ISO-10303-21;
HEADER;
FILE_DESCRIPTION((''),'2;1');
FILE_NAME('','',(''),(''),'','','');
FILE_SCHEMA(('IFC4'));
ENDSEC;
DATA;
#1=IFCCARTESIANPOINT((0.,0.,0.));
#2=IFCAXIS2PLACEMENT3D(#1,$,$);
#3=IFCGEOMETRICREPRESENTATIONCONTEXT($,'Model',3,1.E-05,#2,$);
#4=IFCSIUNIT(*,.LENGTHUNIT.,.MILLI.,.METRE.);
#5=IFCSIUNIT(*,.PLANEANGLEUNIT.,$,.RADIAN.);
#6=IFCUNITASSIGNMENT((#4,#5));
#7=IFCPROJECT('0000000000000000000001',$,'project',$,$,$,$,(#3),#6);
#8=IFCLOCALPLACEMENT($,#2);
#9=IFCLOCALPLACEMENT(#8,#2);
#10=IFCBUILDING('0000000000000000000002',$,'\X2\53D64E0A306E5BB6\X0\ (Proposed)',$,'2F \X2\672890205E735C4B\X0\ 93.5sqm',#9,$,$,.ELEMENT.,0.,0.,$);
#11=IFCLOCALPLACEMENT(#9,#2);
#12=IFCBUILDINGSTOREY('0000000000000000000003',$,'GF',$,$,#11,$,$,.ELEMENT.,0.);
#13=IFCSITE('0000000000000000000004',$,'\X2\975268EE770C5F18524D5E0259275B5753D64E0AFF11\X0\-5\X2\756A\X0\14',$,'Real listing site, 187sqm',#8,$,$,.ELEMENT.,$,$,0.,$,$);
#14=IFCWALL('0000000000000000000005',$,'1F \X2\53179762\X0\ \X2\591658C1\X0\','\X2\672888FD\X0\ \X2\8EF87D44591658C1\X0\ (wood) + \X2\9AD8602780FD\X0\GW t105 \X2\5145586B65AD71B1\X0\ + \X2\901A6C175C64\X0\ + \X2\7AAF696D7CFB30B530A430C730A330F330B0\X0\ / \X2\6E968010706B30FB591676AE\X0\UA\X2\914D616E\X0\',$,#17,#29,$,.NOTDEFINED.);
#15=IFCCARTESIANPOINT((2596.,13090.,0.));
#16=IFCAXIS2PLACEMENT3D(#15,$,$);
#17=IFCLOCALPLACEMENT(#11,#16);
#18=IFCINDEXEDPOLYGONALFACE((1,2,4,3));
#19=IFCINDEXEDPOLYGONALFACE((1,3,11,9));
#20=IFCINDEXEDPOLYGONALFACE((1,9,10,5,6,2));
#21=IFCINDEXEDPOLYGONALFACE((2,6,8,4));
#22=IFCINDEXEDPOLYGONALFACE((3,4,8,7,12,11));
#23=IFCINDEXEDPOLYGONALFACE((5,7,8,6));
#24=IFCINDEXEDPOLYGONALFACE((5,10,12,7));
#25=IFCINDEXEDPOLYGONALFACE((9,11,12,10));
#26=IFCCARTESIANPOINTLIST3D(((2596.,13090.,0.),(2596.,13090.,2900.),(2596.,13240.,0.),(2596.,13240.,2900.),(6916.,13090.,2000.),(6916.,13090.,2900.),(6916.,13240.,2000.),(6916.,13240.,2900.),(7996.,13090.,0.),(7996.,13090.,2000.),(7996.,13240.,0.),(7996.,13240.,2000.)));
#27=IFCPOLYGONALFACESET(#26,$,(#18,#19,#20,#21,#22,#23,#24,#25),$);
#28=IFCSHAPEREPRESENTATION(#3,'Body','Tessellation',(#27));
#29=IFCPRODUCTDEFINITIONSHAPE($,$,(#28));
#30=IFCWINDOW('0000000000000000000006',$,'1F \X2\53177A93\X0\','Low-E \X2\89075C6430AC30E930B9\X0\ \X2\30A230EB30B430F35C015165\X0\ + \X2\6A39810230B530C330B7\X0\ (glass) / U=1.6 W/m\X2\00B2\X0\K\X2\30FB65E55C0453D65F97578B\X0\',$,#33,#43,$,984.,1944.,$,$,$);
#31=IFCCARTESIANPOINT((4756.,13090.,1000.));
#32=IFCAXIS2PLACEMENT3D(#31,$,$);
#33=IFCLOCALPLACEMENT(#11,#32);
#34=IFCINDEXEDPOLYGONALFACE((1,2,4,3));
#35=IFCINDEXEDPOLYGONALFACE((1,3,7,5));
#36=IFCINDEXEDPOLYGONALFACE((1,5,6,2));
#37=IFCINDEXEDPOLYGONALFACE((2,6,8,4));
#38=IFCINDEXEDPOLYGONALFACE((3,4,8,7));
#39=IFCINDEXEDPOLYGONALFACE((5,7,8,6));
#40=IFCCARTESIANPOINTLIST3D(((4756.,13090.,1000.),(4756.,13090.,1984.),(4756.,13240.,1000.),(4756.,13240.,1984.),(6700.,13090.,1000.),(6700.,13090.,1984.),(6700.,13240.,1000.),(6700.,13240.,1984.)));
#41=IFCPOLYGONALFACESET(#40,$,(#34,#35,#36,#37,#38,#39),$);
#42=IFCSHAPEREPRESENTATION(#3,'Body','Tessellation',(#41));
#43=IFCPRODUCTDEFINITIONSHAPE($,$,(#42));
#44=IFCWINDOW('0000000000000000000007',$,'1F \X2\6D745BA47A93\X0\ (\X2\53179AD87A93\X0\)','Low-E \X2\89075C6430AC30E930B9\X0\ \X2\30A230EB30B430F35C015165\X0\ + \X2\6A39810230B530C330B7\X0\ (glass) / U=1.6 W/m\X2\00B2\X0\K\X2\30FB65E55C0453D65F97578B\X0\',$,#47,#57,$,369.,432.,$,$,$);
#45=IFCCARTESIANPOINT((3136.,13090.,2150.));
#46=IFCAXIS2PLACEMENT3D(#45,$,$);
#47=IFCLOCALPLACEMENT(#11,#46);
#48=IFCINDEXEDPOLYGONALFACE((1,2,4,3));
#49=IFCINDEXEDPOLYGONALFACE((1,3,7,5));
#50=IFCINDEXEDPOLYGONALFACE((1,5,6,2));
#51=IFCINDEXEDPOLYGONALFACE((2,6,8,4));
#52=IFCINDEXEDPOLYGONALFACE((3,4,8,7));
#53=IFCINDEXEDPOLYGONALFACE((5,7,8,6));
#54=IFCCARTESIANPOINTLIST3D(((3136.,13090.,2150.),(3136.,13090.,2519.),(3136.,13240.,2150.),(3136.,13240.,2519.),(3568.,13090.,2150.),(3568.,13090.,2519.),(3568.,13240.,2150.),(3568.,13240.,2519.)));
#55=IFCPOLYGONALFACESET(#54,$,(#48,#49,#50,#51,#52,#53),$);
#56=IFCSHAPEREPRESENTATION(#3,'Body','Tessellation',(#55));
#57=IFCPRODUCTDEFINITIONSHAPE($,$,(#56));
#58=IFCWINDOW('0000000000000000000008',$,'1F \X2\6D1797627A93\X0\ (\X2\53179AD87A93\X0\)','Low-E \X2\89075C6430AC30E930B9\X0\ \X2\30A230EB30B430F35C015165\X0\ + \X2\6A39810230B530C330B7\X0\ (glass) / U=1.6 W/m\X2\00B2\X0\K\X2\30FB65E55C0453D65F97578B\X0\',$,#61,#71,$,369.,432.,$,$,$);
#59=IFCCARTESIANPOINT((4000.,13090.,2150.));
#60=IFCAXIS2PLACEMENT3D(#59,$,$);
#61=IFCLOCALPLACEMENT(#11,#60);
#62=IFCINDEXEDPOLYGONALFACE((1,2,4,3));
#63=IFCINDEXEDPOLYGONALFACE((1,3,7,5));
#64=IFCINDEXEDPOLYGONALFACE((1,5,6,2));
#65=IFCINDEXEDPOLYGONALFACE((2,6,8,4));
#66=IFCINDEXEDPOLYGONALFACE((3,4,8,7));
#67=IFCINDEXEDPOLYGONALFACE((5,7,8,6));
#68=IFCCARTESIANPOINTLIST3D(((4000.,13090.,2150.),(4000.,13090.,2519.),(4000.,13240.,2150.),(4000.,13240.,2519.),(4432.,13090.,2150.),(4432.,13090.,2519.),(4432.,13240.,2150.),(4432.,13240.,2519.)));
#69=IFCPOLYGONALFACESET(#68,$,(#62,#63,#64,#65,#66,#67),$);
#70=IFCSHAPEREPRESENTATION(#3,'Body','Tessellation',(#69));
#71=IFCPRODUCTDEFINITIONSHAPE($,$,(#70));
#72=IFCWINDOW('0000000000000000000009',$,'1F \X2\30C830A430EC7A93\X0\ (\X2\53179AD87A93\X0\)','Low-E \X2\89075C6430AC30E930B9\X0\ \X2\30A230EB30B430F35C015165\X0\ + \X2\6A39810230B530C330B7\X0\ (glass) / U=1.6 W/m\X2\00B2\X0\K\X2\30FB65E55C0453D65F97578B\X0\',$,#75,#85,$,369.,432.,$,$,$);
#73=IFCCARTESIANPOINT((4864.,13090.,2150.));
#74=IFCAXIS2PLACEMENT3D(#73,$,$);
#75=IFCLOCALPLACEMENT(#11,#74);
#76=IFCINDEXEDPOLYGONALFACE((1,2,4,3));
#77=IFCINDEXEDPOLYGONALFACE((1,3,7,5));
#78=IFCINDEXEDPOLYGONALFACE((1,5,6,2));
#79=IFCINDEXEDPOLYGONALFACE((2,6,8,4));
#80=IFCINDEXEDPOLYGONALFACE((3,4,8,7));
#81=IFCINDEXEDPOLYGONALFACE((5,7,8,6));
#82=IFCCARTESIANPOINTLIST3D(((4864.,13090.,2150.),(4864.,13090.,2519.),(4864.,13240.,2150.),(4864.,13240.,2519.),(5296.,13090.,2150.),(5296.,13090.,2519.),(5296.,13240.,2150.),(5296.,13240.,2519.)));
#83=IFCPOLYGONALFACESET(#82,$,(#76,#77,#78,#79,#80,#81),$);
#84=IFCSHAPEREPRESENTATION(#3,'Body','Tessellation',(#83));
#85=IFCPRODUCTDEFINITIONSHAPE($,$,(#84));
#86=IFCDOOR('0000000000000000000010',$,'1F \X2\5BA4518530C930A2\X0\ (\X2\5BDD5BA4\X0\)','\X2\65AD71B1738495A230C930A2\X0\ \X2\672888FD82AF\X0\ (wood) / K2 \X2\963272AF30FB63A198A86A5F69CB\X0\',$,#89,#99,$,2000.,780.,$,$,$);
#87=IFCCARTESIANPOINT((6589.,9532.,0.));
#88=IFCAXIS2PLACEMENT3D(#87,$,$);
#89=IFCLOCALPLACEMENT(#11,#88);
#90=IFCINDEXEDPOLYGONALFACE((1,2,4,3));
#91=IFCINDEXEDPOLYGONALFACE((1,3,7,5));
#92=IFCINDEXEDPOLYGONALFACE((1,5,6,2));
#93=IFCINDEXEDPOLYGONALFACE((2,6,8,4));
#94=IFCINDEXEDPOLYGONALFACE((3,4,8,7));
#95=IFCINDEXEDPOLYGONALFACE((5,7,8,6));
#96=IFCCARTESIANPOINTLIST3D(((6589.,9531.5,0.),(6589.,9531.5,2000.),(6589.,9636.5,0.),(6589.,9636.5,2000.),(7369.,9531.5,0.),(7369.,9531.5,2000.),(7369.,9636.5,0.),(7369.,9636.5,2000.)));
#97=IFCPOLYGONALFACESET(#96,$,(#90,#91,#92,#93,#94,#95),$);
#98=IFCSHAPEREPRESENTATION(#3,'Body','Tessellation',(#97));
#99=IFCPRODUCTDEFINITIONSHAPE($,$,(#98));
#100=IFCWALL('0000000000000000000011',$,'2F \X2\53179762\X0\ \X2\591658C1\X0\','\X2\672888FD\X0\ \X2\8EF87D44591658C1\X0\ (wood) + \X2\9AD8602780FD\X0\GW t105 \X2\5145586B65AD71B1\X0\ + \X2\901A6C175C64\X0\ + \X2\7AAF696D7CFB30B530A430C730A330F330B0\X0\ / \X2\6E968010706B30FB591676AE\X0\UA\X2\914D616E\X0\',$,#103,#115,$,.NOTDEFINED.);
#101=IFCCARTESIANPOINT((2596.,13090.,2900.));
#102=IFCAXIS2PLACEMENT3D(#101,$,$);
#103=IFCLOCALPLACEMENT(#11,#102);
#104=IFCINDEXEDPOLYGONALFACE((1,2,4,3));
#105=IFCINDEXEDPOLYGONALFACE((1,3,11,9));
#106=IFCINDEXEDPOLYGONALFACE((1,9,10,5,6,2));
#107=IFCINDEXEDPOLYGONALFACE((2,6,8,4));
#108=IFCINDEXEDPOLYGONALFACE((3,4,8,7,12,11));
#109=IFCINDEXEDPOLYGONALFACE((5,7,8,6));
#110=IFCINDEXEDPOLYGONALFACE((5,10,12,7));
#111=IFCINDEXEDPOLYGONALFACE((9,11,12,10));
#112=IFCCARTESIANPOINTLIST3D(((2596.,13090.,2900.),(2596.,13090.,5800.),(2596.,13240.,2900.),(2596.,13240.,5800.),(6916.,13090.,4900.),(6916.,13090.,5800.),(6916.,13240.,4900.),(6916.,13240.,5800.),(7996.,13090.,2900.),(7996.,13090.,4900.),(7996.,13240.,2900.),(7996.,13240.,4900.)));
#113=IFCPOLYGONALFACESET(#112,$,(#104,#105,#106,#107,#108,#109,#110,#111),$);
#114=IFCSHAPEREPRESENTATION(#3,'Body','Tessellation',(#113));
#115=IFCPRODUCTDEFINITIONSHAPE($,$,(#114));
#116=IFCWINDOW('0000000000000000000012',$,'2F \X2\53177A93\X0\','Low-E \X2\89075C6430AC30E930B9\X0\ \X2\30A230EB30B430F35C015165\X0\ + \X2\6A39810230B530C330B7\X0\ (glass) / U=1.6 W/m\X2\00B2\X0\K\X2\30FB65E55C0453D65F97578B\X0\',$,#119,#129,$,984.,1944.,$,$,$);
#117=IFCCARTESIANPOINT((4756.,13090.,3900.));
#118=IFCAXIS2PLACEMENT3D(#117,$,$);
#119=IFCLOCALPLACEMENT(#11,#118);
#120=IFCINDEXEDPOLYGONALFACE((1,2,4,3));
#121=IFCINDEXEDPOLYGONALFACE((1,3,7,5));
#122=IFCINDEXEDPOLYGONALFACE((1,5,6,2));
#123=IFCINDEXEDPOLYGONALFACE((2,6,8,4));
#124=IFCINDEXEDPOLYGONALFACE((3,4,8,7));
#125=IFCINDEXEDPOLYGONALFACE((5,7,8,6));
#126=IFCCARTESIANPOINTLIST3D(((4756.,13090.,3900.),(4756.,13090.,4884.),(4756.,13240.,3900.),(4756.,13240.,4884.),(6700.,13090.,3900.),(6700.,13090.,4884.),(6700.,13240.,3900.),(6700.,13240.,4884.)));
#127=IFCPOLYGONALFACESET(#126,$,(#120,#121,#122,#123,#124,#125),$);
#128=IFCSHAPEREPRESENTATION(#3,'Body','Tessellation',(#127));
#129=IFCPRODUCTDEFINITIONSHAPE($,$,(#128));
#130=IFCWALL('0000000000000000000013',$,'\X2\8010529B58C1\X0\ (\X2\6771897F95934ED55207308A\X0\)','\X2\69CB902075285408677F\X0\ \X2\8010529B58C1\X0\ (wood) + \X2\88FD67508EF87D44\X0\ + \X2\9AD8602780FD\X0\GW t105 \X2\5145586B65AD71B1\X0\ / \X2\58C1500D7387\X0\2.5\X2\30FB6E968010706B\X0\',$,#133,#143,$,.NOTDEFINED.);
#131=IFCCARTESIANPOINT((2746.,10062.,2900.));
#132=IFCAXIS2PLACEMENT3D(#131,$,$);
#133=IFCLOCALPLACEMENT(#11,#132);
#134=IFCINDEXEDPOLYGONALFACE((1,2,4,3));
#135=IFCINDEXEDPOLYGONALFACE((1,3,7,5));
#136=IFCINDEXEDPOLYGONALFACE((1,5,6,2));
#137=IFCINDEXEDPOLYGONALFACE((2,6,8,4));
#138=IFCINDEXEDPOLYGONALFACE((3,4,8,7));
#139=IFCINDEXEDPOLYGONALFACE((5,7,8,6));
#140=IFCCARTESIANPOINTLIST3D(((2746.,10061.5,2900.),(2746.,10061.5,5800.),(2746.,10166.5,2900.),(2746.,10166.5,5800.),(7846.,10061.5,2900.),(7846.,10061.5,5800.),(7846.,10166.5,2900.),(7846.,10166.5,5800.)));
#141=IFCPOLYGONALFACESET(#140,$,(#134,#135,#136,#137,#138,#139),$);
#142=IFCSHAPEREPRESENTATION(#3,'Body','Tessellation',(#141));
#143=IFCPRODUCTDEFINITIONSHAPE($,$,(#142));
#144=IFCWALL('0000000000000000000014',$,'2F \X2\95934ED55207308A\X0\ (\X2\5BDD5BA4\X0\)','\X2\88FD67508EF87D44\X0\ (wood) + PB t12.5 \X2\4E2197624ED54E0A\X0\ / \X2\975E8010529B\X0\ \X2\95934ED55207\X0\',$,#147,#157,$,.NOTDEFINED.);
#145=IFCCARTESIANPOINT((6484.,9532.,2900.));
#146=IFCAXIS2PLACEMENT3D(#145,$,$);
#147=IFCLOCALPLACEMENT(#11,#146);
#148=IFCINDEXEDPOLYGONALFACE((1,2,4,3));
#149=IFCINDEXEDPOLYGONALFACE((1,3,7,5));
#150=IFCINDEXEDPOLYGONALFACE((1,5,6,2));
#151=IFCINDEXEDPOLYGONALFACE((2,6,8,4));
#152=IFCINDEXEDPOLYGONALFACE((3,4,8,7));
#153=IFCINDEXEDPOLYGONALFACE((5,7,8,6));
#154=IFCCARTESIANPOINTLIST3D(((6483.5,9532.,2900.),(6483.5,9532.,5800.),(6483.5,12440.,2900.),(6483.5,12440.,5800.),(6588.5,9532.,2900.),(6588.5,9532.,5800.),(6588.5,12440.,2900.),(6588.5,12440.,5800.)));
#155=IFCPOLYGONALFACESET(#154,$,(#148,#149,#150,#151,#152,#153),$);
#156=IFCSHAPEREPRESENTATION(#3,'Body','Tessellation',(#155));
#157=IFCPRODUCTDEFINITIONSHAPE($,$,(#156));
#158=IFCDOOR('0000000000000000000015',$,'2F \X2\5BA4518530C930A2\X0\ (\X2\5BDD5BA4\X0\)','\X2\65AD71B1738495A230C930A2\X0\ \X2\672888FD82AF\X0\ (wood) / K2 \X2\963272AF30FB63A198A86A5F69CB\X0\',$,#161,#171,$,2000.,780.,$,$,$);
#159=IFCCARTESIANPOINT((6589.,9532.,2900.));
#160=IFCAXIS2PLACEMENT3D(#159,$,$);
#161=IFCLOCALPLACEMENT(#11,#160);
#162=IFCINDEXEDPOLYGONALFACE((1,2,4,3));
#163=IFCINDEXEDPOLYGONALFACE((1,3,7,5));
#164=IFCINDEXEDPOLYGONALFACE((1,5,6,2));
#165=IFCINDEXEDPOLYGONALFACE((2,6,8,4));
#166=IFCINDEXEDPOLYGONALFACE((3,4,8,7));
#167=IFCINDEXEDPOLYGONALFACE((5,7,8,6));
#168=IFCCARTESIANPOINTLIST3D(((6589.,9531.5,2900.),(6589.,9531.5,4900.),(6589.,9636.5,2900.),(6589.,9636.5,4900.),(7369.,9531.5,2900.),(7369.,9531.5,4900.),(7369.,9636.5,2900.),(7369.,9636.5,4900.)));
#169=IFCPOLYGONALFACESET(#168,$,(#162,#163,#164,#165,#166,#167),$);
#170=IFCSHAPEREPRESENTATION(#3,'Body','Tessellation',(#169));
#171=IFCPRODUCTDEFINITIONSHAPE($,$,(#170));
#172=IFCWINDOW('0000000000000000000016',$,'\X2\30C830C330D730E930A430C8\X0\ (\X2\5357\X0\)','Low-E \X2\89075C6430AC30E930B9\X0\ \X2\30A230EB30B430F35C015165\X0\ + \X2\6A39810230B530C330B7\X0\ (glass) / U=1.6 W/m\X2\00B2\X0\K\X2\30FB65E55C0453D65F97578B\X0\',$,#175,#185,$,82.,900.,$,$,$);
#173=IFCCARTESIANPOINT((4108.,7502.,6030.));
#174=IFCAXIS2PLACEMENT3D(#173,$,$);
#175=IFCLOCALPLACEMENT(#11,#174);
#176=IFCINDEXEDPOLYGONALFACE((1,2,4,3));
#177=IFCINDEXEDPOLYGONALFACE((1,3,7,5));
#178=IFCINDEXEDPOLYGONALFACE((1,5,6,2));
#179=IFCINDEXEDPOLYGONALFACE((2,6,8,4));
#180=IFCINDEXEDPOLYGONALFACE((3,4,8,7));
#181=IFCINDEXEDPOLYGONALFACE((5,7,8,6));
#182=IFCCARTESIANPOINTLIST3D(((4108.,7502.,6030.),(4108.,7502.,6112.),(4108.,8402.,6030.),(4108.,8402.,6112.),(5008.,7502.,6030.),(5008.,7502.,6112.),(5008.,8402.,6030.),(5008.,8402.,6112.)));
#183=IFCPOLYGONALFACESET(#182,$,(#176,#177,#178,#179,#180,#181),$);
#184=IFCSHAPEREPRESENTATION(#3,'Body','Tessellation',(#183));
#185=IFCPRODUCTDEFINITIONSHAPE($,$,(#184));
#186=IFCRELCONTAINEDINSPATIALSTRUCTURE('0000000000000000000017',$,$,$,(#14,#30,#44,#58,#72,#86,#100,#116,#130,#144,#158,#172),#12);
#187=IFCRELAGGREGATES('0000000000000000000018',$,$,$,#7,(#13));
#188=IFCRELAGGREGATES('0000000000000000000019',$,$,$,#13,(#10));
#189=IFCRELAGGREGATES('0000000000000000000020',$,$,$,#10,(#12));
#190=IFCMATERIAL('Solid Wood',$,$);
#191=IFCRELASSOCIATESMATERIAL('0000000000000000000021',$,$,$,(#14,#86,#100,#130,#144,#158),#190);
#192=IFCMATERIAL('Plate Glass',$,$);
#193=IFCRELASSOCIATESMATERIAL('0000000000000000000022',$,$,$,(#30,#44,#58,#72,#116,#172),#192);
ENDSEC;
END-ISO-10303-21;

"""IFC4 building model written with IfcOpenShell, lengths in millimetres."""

from ifc_helpers import new_model, si_unit, frame, frame_2d, origin, place, context, project, spatial, rectangle, extrude, material, element, fill, save


model = new_model("IFC4")

# Units and contexts
model_context = context("Model", 3, precision=1e-05, world=origin())
ifc_project = project(units=[si_unit("LENGTHUNIT", "METRE", prefix="MILLI"), si_unit("PLANEANGLEUNIT", "RADIAN")], contexts=[model_context])

# Site, building, storey
site_placement = place(None, origin())
site = spatial("IfcSite", under=ifc_project, at=site_placement, Name="青森県弘前市大字取上１-5番14", ObjectType="Real listing site, 187sqm", CompositionType="ELEMENT", RefElevation=0.0)
building_placement = place(site_placement, origin())
building = spatial("IfcBuilding", under=site, at=building_placement, Name="取上の家 (Proposed)", ObjectType="2F 木造平屋 93.5sqm", CompositionType="ELEMENT", ElevationOfRefHeight=0.0, ElevationOfTerrain=0.0)
storey_placement = place(building_placement, origin())
storey = spatial("IfcBuildingStorey", under=building, at=storey_placement, Name="GF", CompositionType="ELEMENT", Elevation=0.0)

# Wall, openings, windows
ifc_material_1 = material(Name="Solid Wood")
wall_1_placement = place(storey_placement, frame((2596.0, 13090.0, 0.0)))
wall_1 = element("IfcWall", 1, at=wall_1_placement, inside=storey, material=ifc_material_1, Name="1F 北面 外壁", Description="木製 軸組外壁 (wood) + 高性能GW t105 充填断熱 + 通気層 + 窯業系サイディング / 準耐火・外皮UA配慮", PredefinedType="NOTDEFINED", context=model_context, shape_type="SweptSolid", body=[
    extrude(rectangle(XDim=5400.0, YDim=150.0, at=frame_2d((2700.0, 75.0))), frame((2596.0, 13090.0, 0.0)), (0.0, 0.0, 1.0), 2900.0),
])
opening_1_placement = place(storey_placement, frame((4756.0, 13090.0, 1000.0)))
opening_1 = element("IfcOpeningElement", 2, at=opening_1_placement, cuts=wall_1, PredefinedType="NOTDEFINED", context=model_context, shape_type="SweptSolid", body=[
    extrude(rectangle(XDim=1944.0, YDim=150.0, at=frame_2d((972.0, 75.0))), frame((4756.0, 13090.0, 1000.0)), (0.0, 0.0, 1.0), 984.0),
])
opening_2_placement = place(storey_placement, frame((3136.0, 13090.0, 2150.0)))
opening_2 = element("IfcOpeningElement", 3, at=opening_2_placement, cuts=wall_1, PredefinedType="NOTDEFINED", context=model_context, shape_type="SweptSolid", body=[
    extrude(rectangle(XDim=432.0, YDim=150.0, at=frame_2d((216.0, 75.0))), frame((3136.0, 13090.0, 2150.0)), (0.0, 0.0, 1.0), 369.0),
])
opening_3_placement = place(storey_placement, frame((4000.0, 13090.0, 2150.0)))
opening_3 = element("IfcOpeningElement", 4, at=opening_3_placement, cuts=wall_1, PredefinedType="NOTDEFINED", context=model_context, shape_type="SweptSolid", body=[
    extrude(rectangle(XDim=432.0, YDim=150.0, at=frame_2d((216.0, 75.0))), frame((4000.0, 13090.0, 2150.0)), (0.0, 0.0, 1.0), 369.0),
])
opening_4_placement = place(storey_placement, frame((4864.0, 13090.0, 2150.0)))
opening_4 = element("IfcOpeningElement", 5, at=opening_4_placement, cuts=wall_1, PredefinedType="NOTDEFINED", context=model_context, shape_type="SweptSolid", body=[
    extrude(rectangle(XDim=432.0, YDim=150.0, at=frame_2d((216.0, 75.0))), frame((4864.0, 13090.0, 2150.0)), (0.0, 0.0, 1.0), 369.0),
])
ifc_material_2 = material(Name="Plate Glass")
window_1_placement = place(storey_placement, frame((4756.0, 13090.0, 1000.0)))
window_1 = element("IfcWindow", 6, at=window_1_placement, inside=storey, material=ifc_material_2, Name="1F 北窓", Description="Low-E 複層ガラス アルゴン封入 + 樹脂サッシ (glass) / U=1.6 W/m²K・日射取得型", OverallHeight=984.0, OverallWidth=1944.0, context=model_context, shape_type="SweptSolid", body=[
    extrude(rectangle(XDim=1944.0, YDim=150.0, at=frame_2d((972.0, 75.0))), frame((4756.0, 13090.0, 1000.0)), (0.0, 0.0, 1.0), 984.0),
])
fill(opening_1, window_1)
window_2_placement = place(storey_placement, frame((3136.0, 13090.0, 2150.0)))
window_2 = element("IfcWindow", 7, at=window_2_placement, inside=storey, material=ifc_material_2, Name="1F 浴室窓 (北高窓)", Description="Low-E 複層ガラス アルゴン封入 + 樹脂サッシ (glass) / U=1.6 W/m²K・日射取得型", OverallHeight=369.0, OverallWidth=432.0, context=model_context, shape_type="SweptSolid", body=[
    extrude(rectangle(XDim=432.0, YDim=150.0, at=frame_2d((216.0, 75.0))), frame((3136.0, 13090.0, 2150.0)), (0.0, 0.0, 1.0), 369.0),
])
fill(opening_2, window_2)
window_3_placement = place(storey_placement, frame((4000.0, 13090.0, 2150.0)))
window_3 = element("IfcWindow", 8, at=window_3_placement, inside=storey, material=ifc_material_2, Name="1F 洗面窓 (北高窓)", Description="Low-E 複層ガラス アルゴン封入 + 樹脂サッシ (glass) / U=1.6 W/m²K・日射取得型", OverallHeight=369.0, OverallWidth=432.0, context=model_context, shape_type="SweptSolid", body=[
    extrude(rectangle(XDim=432.0, YDim=150.0, at=frame_2d((216.0, 75.0))), frame((4000.0, 13090.0, 2150.0)), (0.0, 0.0, 1.0), 369.0),
])
fill(opening_3, window_3)
window_4_placement = place(storey_placement, frame((4864.0, 13090.0, 2150.0)))
window_4 = element("IfcWindow", 9, at=window_4_placement, inside=storey, material=ifc_material_2, Name="1F トイレ窓 (北高窓)", Description="Low-E 複層ガラス アルゴン封入 + 樹脂サッシ (glass) / U=1.6 W/m²K・日射取得型", OverallHeight=369.0, OverallWidth=432.0, context=model_context, shape_type="SweptSolid", body=[
    extrude(rectangle(XDim=432.0, YDim=150.0, at=frame_2d((216.0, 75.0))), frame((4864.0, 13090.0, 2150.0)), (0.0, 0.0, 1.0), 369.0),
])
fill(opening_4, window_4)

# Door
door_1_placement = place(storey_placement, frame((6589.0, 9532.0, 0.0)))
element("IfcDoor", 10, at=door_1_placement, inside=storey, material=ifc_material_1, Name="1F 室内ドア (寝室)", Description="断熱玄関ドア 木製芯 (wood) / K2 防犯・採風機構", OverallHeight=2000.0, OverallWidth=780.0, context=model_context, shape_type="SweptSolid", body=[
    extrude(rectangle(XDim=780.0, YDim=105.0, at=frame_2d((390.0, 52.0))), frame((6589.0, 9532.0, 0.0)), (0.0, 0.0, 1.0), 2000.0),
])

# Wall, opening, window
wall_2_placement = place(storey_placement, frame((2596.0, 13090.0, 2900.0)))
wall_2 = element("IfcWall", 11, at=wall_2_placement, inside=storey, material=ifc_material_1, Name="2F 北面 外壁", Description="木製 軸組外壁 (wood) + 高性能GW t105 充填断熱 + 通気層 + 窯業系サイディング / 準耐火・外皮UA配慮", PredefinedType="NOTDEFINED", context=model_context, shape_type="SweptSolid", body=[
    extrude(rectangle(XDim=5400.0, YDim=150.0, at=frame_2d((2700.0, 75.0))), frame((2596.0, 13090.0, 2900.0)), (0.0, 0.0, 1.0), 2900.0),
])
opening_5_placement = place(storey_placement, frame((4756.0, 13090.0, 3900.0)))
opening_5 = element("IfcOpeningElement", 12, at=opening_5_placement, cuts=wall_2, PredefinedType="NOTDEFINED", context=model_context, shape_type="SweptSolid", body=[
    extrude(rectangle(XDim=1944.0, YDim=150.0, at=frame_2d((972.0, 75.0))), frame((4756.0, 13090.0, 3900.0)), (0.0, 0.0, 1.0), 984.0),
])
window_5_placement = place(storey_placement, frame((4756.0, 13090.0, 3900.0)))
window_5 = element("IfcWindow", 13, at=window_5_placement, inside=storey, material=ifc_material_2, Name="2F 北窓", Description="Low-E 複層ガラス アルゴン封入 + 樹脂サッシ (glass) / U=1.6 W/m²K・日射取得型", OverallHeight=984.0, OverallWidth=1944.0, context=model_context, shape_type="SweptSolid", body=[
    extrude(rectangle(XDim=1944.0, YDim=150.0, at=frame_2d((972.0, 75.0))), frame((4756.0, 13090.0, 3900.0)), (0.0, 0.0, 1.0), 984.0),
])
fill(opening_5, window_5)

# Walls
wall_3_placement = place(storey_placement, frame((2746.0, 10062.0, 2900.0)))
element("IfcWall", 14, at=wall_3_placement, inside=storey, material=ifc_material_1, Name="耐力壁 (東西間仕切り)", Description="構造用合板 耐力壁 (wood) + 製材軸組 + 高性能GW t105 充填断熱 / 壁倍率2.5・準耐火", PredefinedType="NOTDEFINED", context=model_context, shape_type="SweptSolid", body=[
    extrude(rectangle(XDim=5100.0, YDim=105.0, at=frame_2d((2550.0, 52.0))), frame((2746.0, 10062.0, 2900.0)), (0.0, 0.0, 1.0), 2900.0),
])
wall_4_placement = place(storey_placement, frame((6484.0, 9532.0, 2900.0)))
element("IfcWall", 15, at=wall_4_placement, inside=storey, material=ifc_material_1, Name="2F 間仕切り (寝室)", Description="製材軸組 (wood) + PB t12.5 両面仕上 / 非耐力 間仕切", PredefinedType="NOTDEFINED", context=model_context, shape_type="SweptSolid", body=[
    extrude(rectangle(XDim=105.0, YDim=2908.0, at=frame_2d((52.0, 1454.0))), frame((6484.0, 9532.0, 2900.0)), (0.0, 0.0, 1.0), 2900.0),
])

# Door
door_2_placement = place(storey_placement, frame((6589.0, 9532.0, 2900.0)))
element("IfcDoor", 16, at=door_2_placement, inside=storey, material=ifc_material_1, Name="2F 室内ドア (寝室)", Description="断熱玄関ドア 木製芯 (wood) / K2 防犯・採風機構", OverallHeight=2000.0, OverallWidth=780.0, context=model_context, shape_type="SweptSolid", body=[
    extrude(rectangle(XDim=780.0, YDim=105.0, at=frame_2d((390.0, 52.0))), frame((6589.0, 9532.0, 2900.0)), (0.0, 0.0, 1.0), 2000.0),
])

# Window
window_6_placement = place(storey_placement, frame((4108.0, 7502.0, 6030.0)))
element("IfcWindow", 17, at=window_6_placement, inside=storey, material=ifc_material_2, Name="トップライト (南)", Description="Low-E 複層ガラス アルゴン封入 + 樹脂サッシ (glass) / U=1.6 W/m²K・日射取得型", OverallHeight=82.0, OverallWidth=900.0, context=model_context, shape_type="SweptSolid", body=[
    extrude(rectangle(XDim=900.0, YDim=900.0, at=frame_2d((450.0, 450.0))), frame((4108.0, 7502.0, 6030.0)), (0.0, 0.0, 1.0), 82.0),
])

save(model, "model.ifc")
